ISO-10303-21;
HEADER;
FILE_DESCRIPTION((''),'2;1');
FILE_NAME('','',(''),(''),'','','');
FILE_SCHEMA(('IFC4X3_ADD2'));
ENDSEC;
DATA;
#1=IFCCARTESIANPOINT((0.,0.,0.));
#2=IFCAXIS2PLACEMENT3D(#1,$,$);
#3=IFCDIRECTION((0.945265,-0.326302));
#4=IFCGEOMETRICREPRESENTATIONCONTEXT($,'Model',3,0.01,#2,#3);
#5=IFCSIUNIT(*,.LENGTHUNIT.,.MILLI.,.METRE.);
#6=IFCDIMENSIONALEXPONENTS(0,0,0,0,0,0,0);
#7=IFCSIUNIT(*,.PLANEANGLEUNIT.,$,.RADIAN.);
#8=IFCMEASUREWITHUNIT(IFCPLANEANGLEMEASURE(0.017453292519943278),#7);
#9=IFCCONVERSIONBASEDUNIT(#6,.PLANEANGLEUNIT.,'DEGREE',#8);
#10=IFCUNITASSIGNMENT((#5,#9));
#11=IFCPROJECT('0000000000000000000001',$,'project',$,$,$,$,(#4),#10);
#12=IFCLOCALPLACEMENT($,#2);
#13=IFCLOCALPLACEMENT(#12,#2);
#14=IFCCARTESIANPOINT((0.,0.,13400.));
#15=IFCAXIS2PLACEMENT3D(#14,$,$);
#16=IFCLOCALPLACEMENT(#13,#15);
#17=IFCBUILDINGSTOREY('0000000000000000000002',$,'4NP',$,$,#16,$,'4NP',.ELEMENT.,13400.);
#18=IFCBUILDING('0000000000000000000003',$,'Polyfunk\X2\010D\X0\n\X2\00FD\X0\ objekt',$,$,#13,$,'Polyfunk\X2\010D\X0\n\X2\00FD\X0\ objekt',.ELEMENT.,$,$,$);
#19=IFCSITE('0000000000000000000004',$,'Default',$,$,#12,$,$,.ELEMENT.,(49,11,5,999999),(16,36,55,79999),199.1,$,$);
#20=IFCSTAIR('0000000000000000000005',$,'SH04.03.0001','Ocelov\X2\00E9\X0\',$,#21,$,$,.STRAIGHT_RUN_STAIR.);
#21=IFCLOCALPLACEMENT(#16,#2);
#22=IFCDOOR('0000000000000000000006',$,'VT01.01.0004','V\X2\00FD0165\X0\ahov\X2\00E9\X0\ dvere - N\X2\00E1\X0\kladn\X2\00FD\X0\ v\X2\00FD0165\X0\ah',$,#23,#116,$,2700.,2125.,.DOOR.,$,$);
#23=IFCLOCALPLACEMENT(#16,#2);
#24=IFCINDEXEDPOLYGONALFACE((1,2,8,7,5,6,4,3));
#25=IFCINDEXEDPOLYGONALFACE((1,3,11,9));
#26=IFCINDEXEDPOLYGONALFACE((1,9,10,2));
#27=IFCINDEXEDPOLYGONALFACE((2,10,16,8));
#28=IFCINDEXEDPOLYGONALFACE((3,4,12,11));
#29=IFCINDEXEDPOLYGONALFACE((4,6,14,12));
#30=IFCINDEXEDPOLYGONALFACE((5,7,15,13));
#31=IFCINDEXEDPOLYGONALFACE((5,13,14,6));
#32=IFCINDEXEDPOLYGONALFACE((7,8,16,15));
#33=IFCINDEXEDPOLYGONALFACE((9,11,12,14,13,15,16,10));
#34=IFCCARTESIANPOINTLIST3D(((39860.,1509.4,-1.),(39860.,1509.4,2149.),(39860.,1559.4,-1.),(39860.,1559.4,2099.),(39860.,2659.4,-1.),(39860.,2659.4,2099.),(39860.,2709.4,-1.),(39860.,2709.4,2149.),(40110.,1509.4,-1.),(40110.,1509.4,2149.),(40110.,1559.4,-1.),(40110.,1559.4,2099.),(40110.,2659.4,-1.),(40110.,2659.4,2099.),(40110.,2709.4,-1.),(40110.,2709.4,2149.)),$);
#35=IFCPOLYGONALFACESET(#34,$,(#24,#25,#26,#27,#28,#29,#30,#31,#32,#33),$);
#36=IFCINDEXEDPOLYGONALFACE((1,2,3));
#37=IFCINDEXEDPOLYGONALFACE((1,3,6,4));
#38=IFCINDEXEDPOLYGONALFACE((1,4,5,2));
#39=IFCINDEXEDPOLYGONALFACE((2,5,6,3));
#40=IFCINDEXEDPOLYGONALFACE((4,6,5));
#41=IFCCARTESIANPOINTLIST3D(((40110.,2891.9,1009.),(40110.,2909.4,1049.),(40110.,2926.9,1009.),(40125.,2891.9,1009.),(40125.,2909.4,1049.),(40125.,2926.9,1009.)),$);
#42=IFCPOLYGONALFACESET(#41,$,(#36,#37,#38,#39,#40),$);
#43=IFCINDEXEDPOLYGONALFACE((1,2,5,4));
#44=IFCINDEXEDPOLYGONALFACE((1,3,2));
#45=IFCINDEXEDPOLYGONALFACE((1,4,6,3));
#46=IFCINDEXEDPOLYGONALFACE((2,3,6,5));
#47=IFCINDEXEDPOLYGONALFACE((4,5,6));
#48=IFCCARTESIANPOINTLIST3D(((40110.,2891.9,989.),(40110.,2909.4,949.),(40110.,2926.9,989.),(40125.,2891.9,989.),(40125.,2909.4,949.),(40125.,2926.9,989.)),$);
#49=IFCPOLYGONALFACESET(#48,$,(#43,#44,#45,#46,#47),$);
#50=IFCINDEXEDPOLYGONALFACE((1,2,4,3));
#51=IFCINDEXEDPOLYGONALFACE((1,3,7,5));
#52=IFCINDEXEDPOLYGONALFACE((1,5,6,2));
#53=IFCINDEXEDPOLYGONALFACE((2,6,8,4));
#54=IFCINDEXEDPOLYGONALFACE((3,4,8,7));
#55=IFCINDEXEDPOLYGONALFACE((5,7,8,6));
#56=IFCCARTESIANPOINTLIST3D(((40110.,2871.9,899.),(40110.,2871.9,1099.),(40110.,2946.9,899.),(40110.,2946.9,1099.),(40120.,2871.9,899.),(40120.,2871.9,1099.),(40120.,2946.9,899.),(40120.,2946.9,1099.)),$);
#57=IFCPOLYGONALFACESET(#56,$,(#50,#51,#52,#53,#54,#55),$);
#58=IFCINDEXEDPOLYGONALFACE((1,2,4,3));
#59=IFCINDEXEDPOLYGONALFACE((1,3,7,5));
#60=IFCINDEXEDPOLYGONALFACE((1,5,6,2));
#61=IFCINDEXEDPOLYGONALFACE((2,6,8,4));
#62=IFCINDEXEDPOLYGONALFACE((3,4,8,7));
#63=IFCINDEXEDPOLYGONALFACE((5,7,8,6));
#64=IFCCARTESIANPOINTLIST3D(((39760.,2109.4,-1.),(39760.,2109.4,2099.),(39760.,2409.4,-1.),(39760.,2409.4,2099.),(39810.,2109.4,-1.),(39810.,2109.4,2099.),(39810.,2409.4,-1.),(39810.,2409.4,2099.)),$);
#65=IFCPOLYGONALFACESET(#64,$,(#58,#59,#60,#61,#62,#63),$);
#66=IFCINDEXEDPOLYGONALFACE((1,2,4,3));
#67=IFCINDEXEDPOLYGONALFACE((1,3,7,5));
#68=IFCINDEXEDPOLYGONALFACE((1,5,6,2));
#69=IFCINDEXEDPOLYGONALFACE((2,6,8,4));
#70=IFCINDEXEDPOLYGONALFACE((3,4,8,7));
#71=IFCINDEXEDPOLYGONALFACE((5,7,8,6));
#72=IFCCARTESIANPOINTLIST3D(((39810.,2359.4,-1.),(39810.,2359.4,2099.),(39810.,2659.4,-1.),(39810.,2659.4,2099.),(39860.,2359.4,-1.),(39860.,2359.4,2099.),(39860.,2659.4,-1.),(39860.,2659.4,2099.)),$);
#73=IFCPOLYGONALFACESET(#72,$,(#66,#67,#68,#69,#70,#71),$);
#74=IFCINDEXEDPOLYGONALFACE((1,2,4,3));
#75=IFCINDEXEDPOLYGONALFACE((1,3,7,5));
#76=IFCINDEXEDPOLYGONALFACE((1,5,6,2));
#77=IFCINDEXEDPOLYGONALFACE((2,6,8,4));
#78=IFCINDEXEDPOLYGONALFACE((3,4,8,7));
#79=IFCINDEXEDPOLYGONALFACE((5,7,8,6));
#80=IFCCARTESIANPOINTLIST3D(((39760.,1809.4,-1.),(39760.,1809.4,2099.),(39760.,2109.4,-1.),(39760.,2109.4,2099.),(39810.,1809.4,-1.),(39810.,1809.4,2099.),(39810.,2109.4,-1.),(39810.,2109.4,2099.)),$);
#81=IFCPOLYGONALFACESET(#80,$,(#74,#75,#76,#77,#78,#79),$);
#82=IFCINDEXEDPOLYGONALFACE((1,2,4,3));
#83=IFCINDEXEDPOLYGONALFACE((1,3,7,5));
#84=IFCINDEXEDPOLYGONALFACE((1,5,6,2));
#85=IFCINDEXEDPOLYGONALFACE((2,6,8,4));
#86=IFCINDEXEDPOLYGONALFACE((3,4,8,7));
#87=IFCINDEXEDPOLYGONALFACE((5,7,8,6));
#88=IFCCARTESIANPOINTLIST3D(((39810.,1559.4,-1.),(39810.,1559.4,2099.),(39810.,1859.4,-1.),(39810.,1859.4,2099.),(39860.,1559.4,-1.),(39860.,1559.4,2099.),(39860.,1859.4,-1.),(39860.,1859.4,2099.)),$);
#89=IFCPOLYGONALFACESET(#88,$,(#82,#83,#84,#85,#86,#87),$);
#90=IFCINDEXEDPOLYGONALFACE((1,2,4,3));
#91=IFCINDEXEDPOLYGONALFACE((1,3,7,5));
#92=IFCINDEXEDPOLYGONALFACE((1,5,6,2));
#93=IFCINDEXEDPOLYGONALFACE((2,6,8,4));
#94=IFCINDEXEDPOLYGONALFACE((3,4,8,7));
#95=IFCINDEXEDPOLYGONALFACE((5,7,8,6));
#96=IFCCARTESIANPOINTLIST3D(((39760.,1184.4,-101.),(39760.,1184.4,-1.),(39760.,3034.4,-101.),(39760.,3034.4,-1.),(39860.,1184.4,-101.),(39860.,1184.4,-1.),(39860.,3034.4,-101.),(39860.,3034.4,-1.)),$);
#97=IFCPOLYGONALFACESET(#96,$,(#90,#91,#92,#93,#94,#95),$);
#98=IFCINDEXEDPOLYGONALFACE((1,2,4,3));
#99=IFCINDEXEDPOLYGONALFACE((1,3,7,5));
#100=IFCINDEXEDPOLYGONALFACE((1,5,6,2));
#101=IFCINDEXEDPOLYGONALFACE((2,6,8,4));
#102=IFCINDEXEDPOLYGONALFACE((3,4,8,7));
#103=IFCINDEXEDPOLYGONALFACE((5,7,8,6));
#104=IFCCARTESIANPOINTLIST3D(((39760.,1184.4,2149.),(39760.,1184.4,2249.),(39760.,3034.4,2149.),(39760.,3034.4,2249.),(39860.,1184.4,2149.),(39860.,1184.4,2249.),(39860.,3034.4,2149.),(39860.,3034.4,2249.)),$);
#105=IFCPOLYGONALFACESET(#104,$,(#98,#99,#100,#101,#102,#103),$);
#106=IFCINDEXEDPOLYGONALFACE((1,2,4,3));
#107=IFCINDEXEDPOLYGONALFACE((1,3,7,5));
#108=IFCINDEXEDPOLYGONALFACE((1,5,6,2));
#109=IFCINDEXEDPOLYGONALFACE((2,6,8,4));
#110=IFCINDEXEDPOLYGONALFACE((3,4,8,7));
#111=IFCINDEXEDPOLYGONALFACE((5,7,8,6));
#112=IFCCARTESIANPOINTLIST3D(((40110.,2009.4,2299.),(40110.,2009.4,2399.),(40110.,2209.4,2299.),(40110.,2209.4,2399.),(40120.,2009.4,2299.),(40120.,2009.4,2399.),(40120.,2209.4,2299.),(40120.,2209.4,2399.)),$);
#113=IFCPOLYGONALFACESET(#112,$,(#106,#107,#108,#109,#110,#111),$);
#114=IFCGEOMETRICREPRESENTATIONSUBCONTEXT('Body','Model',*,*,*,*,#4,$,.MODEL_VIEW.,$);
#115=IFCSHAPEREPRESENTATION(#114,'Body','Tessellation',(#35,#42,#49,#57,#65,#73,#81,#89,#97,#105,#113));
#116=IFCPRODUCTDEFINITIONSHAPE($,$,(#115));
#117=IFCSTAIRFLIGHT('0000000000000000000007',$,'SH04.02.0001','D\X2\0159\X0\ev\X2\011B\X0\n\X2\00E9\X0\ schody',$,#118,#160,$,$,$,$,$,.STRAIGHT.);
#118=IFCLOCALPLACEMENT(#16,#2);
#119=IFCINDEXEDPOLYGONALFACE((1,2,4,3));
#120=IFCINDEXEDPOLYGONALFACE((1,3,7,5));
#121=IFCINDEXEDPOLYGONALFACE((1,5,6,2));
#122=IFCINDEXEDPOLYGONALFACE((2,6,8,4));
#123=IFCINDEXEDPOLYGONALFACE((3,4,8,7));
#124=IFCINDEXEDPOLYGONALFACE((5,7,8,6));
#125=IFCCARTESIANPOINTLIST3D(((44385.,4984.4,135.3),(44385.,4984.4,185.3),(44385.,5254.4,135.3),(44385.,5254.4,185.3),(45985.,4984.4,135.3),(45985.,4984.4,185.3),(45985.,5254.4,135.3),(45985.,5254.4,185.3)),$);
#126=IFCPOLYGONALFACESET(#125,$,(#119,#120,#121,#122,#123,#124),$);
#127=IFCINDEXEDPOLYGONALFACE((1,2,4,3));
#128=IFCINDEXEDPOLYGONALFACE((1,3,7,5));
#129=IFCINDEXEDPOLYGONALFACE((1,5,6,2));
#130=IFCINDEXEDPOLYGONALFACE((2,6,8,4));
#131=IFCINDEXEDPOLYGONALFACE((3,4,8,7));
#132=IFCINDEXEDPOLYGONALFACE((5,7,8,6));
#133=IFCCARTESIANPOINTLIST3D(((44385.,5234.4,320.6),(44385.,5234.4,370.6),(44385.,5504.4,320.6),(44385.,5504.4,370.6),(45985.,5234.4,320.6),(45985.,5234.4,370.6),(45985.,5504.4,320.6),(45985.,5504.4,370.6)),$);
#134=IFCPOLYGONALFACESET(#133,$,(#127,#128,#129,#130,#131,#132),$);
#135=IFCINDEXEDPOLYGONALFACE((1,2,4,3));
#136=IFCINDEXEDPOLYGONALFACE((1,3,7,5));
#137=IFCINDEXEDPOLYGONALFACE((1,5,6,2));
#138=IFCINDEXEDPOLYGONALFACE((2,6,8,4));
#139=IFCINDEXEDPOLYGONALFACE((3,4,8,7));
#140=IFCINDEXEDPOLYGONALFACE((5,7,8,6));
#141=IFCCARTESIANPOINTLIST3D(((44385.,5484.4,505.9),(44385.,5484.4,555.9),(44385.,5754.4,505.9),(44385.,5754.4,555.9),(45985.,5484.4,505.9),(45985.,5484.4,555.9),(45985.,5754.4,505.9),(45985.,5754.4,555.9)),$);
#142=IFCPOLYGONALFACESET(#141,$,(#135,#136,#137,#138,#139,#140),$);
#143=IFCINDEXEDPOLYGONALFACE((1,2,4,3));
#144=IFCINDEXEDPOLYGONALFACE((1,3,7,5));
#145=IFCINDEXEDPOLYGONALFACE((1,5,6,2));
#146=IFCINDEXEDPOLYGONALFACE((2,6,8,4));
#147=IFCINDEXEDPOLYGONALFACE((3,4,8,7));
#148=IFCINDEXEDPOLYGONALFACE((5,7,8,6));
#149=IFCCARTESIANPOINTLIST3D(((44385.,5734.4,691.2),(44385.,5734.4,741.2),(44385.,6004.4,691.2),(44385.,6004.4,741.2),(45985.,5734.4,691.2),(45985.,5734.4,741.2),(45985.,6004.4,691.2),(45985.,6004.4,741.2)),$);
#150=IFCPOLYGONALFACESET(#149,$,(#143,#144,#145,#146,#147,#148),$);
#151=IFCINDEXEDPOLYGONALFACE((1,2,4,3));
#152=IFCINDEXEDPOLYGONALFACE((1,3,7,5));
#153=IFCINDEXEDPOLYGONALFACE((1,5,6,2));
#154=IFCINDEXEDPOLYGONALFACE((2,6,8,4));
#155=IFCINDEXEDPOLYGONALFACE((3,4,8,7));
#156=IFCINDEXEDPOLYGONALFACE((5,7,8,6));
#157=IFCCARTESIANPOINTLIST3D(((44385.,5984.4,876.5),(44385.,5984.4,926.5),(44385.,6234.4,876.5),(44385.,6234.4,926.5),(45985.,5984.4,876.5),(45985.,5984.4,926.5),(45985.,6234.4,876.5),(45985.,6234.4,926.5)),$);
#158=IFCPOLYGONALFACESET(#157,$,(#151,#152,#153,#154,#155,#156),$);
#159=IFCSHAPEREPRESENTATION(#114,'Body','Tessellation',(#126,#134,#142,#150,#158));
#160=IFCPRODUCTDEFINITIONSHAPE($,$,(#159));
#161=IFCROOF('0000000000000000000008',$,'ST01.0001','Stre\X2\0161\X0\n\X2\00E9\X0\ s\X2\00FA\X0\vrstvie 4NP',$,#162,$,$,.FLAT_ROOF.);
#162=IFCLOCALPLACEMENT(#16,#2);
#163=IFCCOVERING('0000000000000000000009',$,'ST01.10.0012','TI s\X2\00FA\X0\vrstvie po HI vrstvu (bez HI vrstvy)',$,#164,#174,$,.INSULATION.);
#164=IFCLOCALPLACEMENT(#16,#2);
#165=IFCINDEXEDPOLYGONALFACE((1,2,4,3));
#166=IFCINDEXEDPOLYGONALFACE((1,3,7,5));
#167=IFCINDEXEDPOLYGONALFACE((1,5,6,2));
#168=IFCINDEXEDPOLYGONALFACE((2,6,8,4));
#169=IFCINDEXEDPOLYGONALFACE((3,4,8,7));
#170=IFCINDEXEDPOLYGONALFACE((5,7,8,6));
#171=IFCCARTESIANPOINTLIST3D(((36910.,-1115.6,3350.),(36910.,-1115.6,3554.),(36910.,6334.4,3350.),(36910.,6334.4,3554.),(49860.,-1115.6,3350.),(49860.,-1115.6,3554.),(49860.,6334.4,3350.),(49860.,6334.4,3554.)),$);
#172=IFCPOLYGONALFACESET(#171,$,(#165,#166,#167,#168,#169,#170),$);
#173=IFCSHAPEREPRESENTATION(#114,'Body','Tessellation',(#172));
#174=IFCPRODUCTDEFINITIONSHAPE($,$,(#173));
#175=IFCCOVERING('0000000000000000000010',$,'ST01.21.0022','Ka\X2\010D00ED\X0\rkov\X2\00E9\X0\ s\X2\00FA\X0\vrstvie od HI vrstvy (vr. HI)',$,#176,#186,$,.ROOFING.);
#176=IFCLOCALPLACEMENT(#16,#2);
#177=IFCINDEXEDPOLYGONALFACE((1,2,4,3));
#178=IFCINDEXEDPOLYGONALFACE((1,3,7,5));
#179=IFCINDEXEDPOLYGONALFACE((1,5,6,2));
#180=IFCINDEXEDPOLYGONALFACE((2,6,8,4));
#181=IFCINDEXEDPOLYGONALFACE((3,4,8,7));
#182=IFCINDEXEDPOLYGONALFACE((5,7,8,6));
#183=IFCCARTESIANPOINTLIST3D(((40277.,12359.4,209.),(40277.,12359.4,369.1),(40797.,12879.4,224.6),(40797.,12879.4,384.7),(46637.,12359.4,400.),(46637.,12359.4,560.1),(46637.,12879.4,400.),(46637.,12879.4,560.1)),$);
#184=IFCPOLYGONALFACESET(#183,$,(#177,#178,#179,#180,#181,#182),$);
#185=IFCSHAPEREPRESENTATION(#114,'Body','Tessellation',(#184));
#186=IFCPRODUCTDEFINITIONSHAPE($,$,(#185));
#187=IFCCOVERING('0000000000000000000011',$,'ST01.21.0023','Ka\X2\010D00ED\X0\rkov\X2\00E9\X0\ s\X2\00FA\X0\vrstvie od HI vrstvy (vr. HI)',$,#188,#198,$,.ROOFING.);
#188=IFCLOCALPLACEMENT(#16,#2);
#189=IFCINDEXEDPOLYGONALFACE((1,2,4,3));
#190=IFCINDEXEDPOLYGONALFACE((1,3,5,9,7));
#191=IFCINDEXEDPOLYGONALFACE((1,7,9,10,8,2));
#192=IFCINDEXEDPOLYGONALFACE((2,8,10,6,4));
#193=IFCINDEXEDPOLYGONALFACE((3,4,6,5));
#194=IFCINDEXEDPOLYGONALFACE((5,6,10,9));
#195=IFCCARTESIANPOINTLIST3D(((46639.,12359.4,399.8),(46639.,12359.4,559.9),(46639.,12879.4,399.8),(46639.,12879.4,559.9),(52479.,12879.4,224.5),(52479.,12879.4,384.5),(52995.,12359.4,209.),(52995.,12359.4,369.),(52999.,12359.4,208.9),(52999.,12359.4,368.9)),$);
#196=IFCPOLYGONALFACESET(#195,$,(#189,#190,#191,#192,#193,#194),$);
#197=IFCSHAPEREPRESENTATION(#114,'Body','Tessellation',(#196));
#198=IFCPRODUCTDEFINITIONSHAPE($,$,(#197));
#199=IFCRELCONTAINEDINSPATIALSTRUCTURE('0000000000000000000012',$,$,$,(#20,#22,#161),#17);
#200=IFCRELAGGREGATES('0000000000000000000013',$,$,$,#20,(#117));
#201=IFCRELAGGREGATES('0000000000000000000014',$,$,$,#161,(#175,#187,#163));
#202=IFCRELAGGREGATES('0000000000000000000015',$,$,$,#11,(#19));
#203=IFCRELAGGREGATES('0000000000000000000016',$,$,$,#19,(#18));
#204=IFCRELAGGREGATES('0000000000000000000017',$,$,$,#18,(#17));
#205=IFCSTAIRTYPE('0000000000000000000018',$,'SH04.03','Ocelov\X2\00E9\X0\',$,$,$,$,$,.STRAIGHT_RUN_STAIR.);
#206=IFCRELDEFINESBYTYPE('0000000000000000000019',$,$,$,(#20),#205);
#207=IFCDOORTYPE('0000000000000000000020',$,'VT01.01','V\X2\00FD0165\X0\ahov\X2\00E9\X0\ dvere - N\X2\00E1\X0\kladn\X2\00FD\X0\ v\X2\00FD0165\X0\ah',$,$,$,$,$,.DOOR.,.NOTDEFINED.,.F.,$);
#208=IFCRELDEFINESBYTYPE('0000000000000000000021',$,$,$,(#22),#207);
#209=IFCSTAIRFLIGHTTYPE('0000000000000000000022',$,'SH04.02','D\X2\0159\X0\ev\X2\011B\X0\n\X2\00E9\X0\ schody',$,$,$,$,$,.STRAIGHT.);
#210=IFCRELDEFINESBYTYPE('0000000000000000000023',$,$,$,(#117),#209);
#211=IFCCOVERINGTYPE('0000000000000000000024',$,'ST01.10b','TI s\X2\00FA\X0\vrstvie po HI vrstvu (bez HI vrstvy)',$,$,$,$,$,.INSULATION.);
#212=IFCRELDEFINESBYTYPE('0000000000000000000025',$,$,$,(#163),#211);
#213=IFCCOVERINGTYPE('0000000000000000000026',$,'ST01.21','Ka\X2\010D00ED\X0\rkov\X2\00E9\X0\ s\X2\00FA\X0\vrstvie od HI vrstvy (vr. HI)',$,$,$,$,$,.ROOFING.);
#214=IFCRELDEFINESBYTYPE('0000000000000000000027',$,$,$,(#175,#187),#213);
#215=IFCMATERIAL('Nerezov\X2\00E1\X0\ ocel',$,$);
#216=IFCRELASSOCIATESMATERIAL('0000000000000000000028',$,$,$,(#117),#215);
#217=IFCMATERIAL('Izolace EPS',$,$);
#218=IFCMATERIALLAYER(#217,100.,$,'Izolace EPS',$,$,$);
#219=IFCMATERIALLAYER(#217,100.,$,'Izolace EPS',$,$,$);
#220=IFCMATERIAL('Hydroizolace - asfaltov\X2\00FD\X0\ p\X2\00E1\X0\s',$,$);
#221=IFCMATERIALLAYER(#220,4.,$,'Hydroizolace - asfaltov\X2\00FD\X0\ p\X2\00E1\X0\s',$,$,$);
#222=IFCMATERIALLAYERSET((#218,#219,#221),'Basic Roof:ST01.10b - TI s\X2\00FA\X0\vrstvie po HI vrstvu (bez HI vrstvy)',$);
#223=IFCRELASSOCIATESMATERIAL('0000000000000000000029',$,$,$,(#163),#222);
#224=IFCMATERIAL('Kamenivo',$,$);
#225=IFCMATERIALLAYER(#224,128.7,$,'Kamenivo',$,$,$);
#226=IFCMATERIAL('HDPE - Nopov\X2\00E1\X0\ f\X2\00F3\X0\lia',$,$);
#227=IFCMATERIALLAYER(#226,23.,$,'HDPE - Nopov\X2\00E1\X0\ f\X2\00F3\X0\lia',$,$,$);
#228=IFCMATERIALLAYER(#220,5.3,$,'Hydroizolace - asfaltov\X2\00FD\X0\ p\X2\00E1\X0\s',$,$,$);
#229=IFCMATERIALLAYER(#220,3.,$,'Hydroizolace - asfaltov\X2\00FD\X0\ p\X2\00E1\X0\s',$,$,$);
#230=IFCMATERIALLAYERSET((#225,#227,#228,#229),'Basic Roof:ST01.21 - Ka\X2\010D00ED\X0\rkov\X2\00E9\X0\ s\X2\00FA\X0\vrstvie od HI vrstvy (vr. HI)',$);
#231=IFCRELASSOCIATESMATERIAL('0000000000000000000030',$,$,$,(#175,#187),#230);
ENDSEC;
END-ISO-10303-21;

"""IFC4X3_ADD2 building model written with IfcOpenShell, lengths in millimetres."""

from ifc_helpers import new_model, entity, si_unit, converted_unit, direction, frame, frame_2d, origin, origin_2d_with_axis, place, context, subcontext, project, spatial, polyline, rectangle, outline, extrude, source, transform, mapped, material, layer, layer_set, type_object, type_shapes, element, aggregate, save


model = new_model("IFC4X3_ADD2")

# Units and contexts
model_context = context("Model", 3, precision=0.01, world=origin(), true_north=direction((0.945265, -0.326302)))
body_context = subcontext(model_context, "Body", "Model", "MODEL_VIEW")
ifc_project = project(units=[si_unit("LENGTHUNIT", "METRE", prefix="MILLI"), converted_unit("PLANEANGLEUNIT", "DEGREE", entity("IfcPlaneAngleMeasure", 0.017453292519943278), si_unit("PLANEANGLEUNIT", "RADIAN"), dimensions=[0, 0, 0, 0, 0, 0, 0])], contexts=[model_context])

# Site, building, storey
site_placement = place(None, origin())
site = spatial("IfcSite", under=ifc_project, at=site_placement, Name="Default", CompositionType="ELEMENT", RefLatitude=(49, 11, 5, 999999), RefLongitude=(16, 36, 55, 79999), RefElevation=199.1)
building_placement = place(site_placement, origin())
building = spatial("IfcBuilding", under=site, at=building_placement, Name="Polyfunkčný objekt", LongName="Polyfunkčný objekt", CompositionType="ELEMENT")
storey_placement = place(building_placement, frame((0.0, 0.0, 13400.0)))
storey = spatial("IfcBuildingStorey", under=building, at=storey_placement, Name="4NP", LongName="4NP", CompositionType="ELEMENT", Elevation=13400.0)

# Shared definitions
ifc_material_1 = material(Name="Nerezová ocel")

# Stair
stair_type = type_object("IfcStairType", Name="SH04.03", Description="Ocelové", PredefinedType="STRAIGHT_RUN_STAIR")
stair_placement = place(storey_placement, origin())
stair = element("IfcStair", 1, at=stair_placement, inside=storey, type_object=stair_type, Name="SH04.03.0001", Description="Ocelové", PredefinedType="STRAIGHT_RUN_STAIR")

# Door
door_type_1 = type_object("IfcDoorType", Name="VT01.01", Description="Výťahové dvere - Nákladný výťah", OperationType="NOTDEFINED", ParameterTakesPrecedence=False, PredefinedType="DOOR")
shared_shape_1 = source(origin(), body_context, "Body", "SweptSolid", [
    extrude(outline(polyline([(-1087.5, -600.0), (1062.5, -600.0), (1062.5, -550.0), (-1037.5, -550.0), (-1037.5, 550.0), (1062.5, 550.0), (1062.5, 600.0), (-1087.5, 600.0), (-1087.5, -600.0)])), frame((600.0, 0.0, 1062.5), z_axis=(0.0, 1.0, 0.0), x_axis=(0.0, 0.0, -1.0)), (0.0, 0.0, 1.0), 250.0),
    extrude(outline(polyline([(-24.4, -10.7), (19.2, -10.7), (5.2, 21.4), (-24.4, -10.7)])), frame((1400.0, -15.0, 1023.3), z_axis=(0.0, 1.0, 0.0), x_axis=(0.400819, 0.0, -0.916157)), (0.0, 0.0, 1.0), 15.0),
    extrude(outline(polyline([(-24.4, -10.7), (19.2, -10.7), (5.2, 21.4), (-24.4, -10.7)])), frame((1400.0, -15.0, 976.7), z_axis=(0.0, 1.0, 0.0), x_axis=(-0.400819, 0.0, 0.916157)), (0.0, 0.0, 1.0), 15.0),
    extrude(rectangle(XDim=10.0, YDim=75.0, at=frame_2d((0.0, 0.0), x_axis=(1.0, 0.0))), frame((1400.0, -5.0, 900.0), z_axis=(0.0, 0.0, 1.0), x_axis=(0.0, 1.0, 0.0)), (0.0, 0.0, 1.0), 200.0),
    extrude(rectangle(XDim=50.0, YDim=300.0, at=origin_2d_with_axis()), frame((750.0, 325.0, 0.0), z_axis=(0.0, 0.0, 1.0), x_axis=(0.0, -1.0, 0.0)), (0.0, 0.0, 1.0), 2100.0),
    extrude(rectangle(XDim=50.0, YDim=300.0, at=frame_2d((0.0, 0.0), x_axis=(1.0, 0.0))), frame((1000.0, 275.0, 0.0), z_axis=(0.0, 0.0, 1.0), x_axis=(0.0, -1.0, 0.0)), (0.0, 0.0, 1.0), 2100.0),
    extrude(rectangle(XDim=300.0, YDim=50.0, at=frame_2d((0.0, 0.0), x_axis=(1.0, 0.0))), frame((450.0, 325.0, 0.0), z_axis=(0.0, 0.0, 1.0), x_axis=(-1.0, 0.0, 0.0)), (0.0, 0.0, 1.0), 2100.0),
    extrude(rectangle(XDim=300.0, YDim=50.0, at=frame_2d((0.0, 0.0), x_axis=(1.0, 0.0))), frame((200.0, 275.0, 0.0), z_axis=(0.0, 0.0, 1.0), x_axis=(-1.0, 0.0, 0.0)), (0.0, 0.0, 1.0), 2100.0),
    extrude(rectangle(XDim=1850.0, YDim=100.0, at=frame_2d((0.0, 0.0), x_axis=(1.0, 0.0))), frame((600.0, 300.0, -100.0), z_axis=(0.0, 0.0, 1.0), x_axis=(-1.0, 0.0, 0.0)), (0.0, 0.0, 1.0), 100.0),
    extrude(rectangle(XDim=1850.0, YDim=100.0, at=frame_2d((0.0, 0.0), x_axis=(1.0, 0.0))), frame((600.0, 300.0, 2150.0), z_axis=(0.0, 0.0, 1.0), x_axis=(-1.0, 0.0, 0.0)), (0.0, 0.0, 1.0), 100.0),
    extrude(rectangle(XDim=10.0, YDim=200.0, at=frame_2d((0.0, 0.0), x_axis=(1.0, 0.0))), frame((600.0, -5.0, 2300.0), z_axis=(0.0, 0.0, 1.0), x_axis=(0.0, 1.0, 0.0)), (0.0, 0.0, 1.0), 100.0),
])
type_shapes(door_type_1, [shared_shape_1])
door_1_placement = place(storey_placement, frame((40110.0, 1509.4, -1.0), z_axis=(0.0, 0.0, 1.0), x_axis=(0.0, 1.0, 0.0)))
element("IfcDoor", 2, at=door_1_placement, inside=storey, type_object=door_type_1, Name="VT01.01.0004", Description="Výťahové dvere - Nákladný výťah", OverallHeight=2700.0, OverallWidth=2125.0, PredefinedType="DOOR", context=body_context, shape_type="MappedRepresentation", body=[
    mapped(shared_shape_1, transform((0.0, 0.0, 0.0), scale=1.0)),
])

# Stair flight
stair_flight_type = type_object("IfcStairFlightType", Name="SH04.02", Description="Dřevěné schody", PredefinedType="STRAIGHT")
stair_flight_placement = place(stair_placement, frame((44385.0, 4984.4, 0.0)))
stair_flight = element("IfcStairFlight", 3, at=stair_flight_placement, type_object=stair_flight_type, material=ifc_material_1, Name="SH04.02.0001", Description="Dřevěné schody", PredefinedType="STRAIGHT", context=body_context, shape_type="SweptSolid", body=[
    extrude(rectangle(XDim=270.0, YDim=1600.0, at=origin_2d_with_axis()), frame((800.0, 135.0, 135.3), z_axis=(0.0, 0.0, 1.0), x_axis=(0.0, -1.0, 0.0)), (0.0, 0.0, 1.0), 50.0),
    extrude(rectangle(XDim=270.0, YDim=1600.0, at=origin_2d_with_axis()), frame((800.0, 385.0, 320.6), z_axis=(0.0, 0.0, 1.0), x_axis=(0.0, -1.0, 0.0)), (0.0, 0.0, 1.0), 50.0),
    extrude(rectangle(XDim=270.0, YDim=1600.0, at=origin_2d_with_axis()), frame((800.0, 635.0, 505.9), z_axis=(0.0, 0.0, 1.0), x_axis=(0.0, -1.0, 0.0)), (0.0, 0.0, 1.0), 50.0),
    extrude(rectangle(XDim=270.0, YDim=1600.0, at=origin_2d_with_axis()), frame((800.0, 885.0, 691.2), z_axis=(0.0, 0.0, 1.0), x_axis=(0.0, -1.0, 0.0)), (0.0, 0.0, 1.0), 50.0),
    extrude(rectangle(XDim=250.0, YDim=1600.0, at=origin_2d_with_axis()), frame((800.0, 1125.0, 876.5), z_axis=(0.0, 0.0, 1.0), x_axis=(0.0, -1.0, 0.0)), (0.0, 0.0, 1.0), 50.0),
])
aggregate(stair, [stair_flight])

# Roof, coverings
roof = element("IfcRoof", 4, inside=storey, Name="ST01.0001", Description="Strešné súvrstvie 4NP", PredefinedType="FLAT_ROOF")
ifc_material_2 = material(Name="Izolace EPS")
ifc_layer_1 = layer(ifc_material_2, 100.0, Name="Izolace EPS")
ifc_layer_2 = layer(ifc_material_2, 100.0, Name="Izolace EPS")
ifc_material_3 = material(Name="Hydroizolace - asfaltový pás")
ifc_layer_3 = layer(ifc_material_3, 4.0, Name="Hydroizolace - asfaltový pás")
ifc_layer_set_1 = layer_set([ifc_layer_1, ifc_layer_2, ifc_layer_3], Name="Basic Roof:ST01.10b - TI súvrstvie po HI vrstvu (bez HI vrstvy)")
covering_type_1 = type_object("IfcCoveringType", Name="ST01.10b", Description="TI súvrstvie po HI vrstvu (bez HI vrstvy)", PredefinedType="INSULATION")
covering_1_placement = place(storey_placement, frame((36910.0, -1115.6, 3350.0)))
covering_1 = element("IfcCovering", 5, at=covering_1_placement, type_object=covering_type_1, material=ifc_layer_set_1, Name="ST01.10.0012", Description="TI súvrstvie po HI vrstvu (bez HI vrstvy)", PredefinedType="INSULATION", context=body_context, shape_type="SweptSolid", body=[
    extrude(rectangle(XDim=7450.0, YDim=12950.0, at=origin_2d_with_axis()), frame((6475.0, 3725.0, 0.0), z_axis=(0.0, 0.0, 1.0), x_axis=(0.0, -1.0, 0.0)), (0.0, 0.0, 1.0), 204.0),
])
ifc_material_4 = material(Name="Kamenivo")
ifc_layer_4 = layer(ifc_material_4, 128.7, Name="Kamenivo")
ifc_material_5 = material(Name="HDPE - Nopová fólia")
ifc_layer_5 = layer(ifc_material_5, 23.0, Name="HDPE - Nopová fólia")
ifc_layer_6 = layer(ifc_material_3, 5.3, Name="Hydroizolace - asfaltový pás")
ifc_layer_7 = layer(ifc_material_3, 3.0, Name="Hydroizolace - asfaltový pás")
ifc_layer_set_2 = layer_set([ifc_layer_4, ifc_layer_5, ifc_layer_6, ifc_layer_7], Name="Basic Roof:ST01.21 - Kačírkové súvrstvie od HI vrstvy (vr. HI)")
covering_type_2 = type_object("IfcCoveringType", Name="ST01.21", Description="Kačírkové súvrstvie od HI vrstvy (vr. HI)", PredefinedType="ROOFING")
placement_1 = place(storey_placement, frame((40277.0, 12359.4, 209.0)))
covering_2_placement = place(placement_1, origin())
covering_2 = element("IfcCovering", 6, at=covering_2_placement, type_object=covering_type_2, material=ifc_layer_set_2, Name="ST01.21.0022", Description="Kačírkové súvrstvie od HI vrstvy (vr. HI)", PredefinedType="ROOFING", context=body_context, shape_type="SweptSolid", body=[
    extrude(outline(polyline([(-3181.4, -260.0), (3181.4, -260.0), (3181.4, 260.0), (-2661.2, 260.0), (-3181.4, -260.0)])), frame((3180.0, 260.0, 95.5), z_axis=(-0.030015, 0.0, 0.999549), x_axis=(0.999549, 0.0, 0.030015)), (0.030015, 0.0, 0.999549), 160.1),
])
placement_2 = place(storey_placement, frame((46639.0, 12359.4, 208.9)))
covering_3_placement = place(placement_2, origin())
covering_3 = element("IfcCovering", 7, at=covering_3_placement, type_object=covering_type_2, material=ifc_layer_set_2, Name="ST01.21.0023", Description="Kačírkové súvrstvie od HI vrstvy (vr. HI)", PredefinedType="ROOFING", context=body_context, shape_type="SweptSolid", body=[
    extrude(outline(polyline([(2661.2, 260.0), (-3181.4, 260.0), (-3181.4, -260.0), (3177.4, -260.0), (3181.4, -260.0), (2661.2, 260.0)])), frame((3180.0, 260.0, 95.5), z_axis=(0.030015, 0.0, 0.999549), x_axis=(0.999549, 0.0, -0.030015)), (-0.030015, 0.0, 0.999549), 160.1),
])
aggregate(roof, [covering_2, covering_3, covering_1])

save(model, "model.ifc")
